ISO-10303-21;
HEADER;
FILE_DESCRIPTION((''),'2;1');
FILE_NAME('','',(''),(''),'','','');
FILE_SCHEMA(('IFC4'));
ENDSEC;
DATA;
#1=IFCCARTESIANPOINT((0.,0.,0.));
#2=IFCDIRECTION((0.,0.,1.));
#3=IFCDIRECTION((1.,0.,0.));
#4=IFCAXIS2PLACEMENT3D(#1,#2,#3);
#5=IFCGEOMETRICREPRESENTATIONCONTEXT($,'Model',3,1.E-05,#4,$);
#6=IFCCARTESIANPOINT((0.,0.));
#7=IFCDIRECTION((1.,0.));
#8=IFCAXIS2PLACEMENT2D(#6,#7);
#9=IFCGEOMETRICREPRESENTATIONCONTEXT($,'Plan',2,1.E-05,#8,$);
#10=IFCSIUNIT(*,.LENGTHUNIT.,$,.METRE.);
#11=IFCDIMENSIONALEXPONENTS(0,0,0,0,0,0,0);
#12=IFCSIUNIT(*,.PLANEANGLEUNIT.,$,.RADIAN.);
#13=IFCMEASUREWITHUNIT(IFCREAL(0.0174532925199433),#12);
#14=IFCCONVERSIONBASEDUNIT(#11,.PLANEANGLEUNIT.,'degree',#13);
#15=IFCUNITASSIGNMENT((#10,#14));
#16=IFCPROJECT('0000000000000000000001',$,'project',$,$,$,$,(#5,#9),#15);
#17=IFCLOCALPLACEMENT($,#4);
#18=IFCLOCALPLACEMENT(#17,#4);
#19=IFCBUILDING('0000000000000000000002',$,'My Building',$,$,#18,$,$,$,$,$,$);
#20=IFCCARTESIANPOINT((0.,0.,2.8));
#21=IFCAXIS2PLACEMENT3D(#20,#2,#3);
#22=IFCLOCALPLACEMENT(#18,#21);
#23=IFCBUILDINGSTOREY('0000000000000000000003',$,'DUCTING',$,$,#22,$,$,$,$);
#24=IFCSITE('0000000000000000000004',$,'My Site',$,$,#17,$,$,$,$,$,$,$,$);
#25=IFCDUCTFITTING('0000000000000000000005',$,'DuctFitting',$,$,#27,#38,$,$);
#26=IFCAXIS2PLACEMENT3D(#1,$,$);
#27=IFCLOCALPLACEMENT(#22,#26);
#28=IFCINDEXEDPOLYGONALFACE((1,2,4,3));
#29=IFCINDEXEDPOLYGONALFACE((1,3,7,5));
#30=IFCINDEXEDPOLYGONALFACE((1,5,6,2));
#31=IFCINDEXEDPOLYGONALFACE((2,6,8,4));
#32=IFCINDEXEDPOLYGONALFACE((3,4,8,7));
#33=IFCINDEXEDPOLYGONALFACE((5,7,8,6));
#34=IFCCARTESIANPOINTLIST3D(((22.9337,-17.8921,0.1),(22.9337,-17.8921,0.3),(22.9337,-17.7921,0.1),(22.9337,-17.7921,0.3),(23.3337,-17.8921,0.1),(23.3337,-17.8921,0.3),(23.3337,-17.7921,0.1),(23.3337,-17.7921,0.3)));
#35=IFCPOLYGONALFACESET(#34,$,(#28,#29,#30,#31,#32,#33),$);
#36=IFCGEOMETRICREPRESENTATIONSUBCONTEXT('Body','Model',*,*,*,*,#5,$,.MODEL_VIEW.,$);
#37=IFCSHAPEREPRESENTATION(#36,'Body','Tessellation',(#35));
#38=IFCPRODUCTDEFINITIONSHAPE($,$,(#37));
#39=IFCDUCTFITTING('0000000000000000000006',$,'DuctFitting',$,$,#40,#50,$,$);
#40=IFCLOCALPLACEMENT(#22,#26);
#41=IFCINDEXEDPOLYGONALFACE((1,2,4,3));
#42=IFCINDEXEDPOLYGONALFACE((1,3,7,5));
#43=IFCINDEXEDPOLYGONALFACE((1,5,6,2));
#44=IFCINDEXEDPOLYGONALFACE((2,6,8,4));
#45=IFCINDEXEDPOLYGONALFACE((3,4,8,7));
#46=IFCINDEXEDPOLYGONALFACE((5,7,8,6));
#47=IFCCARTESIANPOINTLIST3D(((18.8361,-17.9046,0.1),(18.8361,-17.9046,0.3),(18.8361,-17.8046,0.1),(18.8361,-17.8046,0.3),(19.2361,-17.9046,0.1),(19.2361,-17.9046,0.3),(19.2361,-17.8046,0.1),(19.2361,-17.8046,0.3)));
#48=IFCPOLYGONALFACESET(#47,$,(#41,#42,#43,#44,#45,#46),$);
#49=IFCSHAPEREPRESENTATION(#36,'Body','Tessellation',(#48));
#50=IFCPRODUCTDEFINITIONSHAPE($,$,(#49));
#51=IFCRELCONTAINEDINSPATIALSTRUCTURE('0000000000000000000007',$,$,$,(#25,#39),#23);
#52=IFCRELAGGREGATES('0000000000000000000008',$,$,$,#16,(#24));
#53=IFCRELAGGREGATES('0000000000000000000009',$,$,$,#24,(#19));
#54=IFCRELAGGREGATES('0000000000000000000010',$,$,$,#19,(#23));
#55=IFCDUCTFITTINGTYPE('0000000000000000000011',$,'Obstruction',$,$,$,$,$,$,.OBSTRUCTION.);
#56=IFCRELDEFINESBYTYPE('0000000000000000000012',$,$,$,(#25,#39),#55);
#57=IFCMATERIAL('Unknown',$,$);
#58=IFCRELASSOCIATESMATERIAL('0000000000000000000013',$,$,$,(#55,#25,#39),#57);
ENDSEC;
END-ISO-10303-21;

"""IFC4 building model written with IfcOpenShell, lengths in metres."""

from ifc_helpers import new_model, entity, si_unit, converted_unit, frame, origin_with_axes, origin_2d_with_axis, place, context, subcontext, project, spatial, rectangle, extrude, material, material_profile, profile_set, profile_usage, type_object, element, save


model = new_model("IFC4")

# Units and contexts
model_context = context("Model", 3, precision=1e-05, world=origin_with_axes())
plan_context = context("Plan", 2, precision=1e-05, world=origin_2d_with_axis())
body_context = subcontext(model_context, "Body", "Model", "MODEL_VIEW")
ifc_project = project(units=[si_unit("LENGTHUNIT", "METRE"), converted_unit("PLANEANGLEUNIT", "degree", entity("IfcReal", 0.0174532925199433), si_unit("PLANEANGLEUNIT", "RADIAN"), dimensions=[0, 0, 0, 0, 0, 0, 0])], contexts=[model_context, plan_context])

# Site, building, storey
site_placement = place(None, origin_with_axes())
site = spatial("IfcSite", under=ifc_project, at=site_placement, Name="My Site")
building_placement = place(site_placement, origin_with_axes())
building = spatial("IfcBuilding", under=site, at=building_placement, Name="My Building")
storey_placement = place(building_placement, frame((0.0, 0.0, 2.8), z_axis=(0.0, 0.0, 1.0), x_axis=(1.0, 0.0, 0.0)))
storey = spatial("IfcBuildingStorey", under=building, at=storey_placement, Name="DUCTING")

# Shared definitions
ifc_material = material(Name="Unknown")

# Duct fittings
ifc_material_profile_1 = material_profile(ifc_material, rectangle(XDim=0.4, YDim=0.2))
ifc_profile_set_1 = profile_set([ifc_material_profile_1])
duct_fitting_type_1 = type_object("IfcDuctFittingType", Name="Obstruction", PredefinedType="OBSTRUCTION", material=ifc_profile_set_1)
ifc_profile_usage_1 = profile_usage(ifc_profile_set_1, cardinal=5)
duct_fitting_1_placement = place(storey_placement, frame((23.1337, -17.8921, 0.2), z_axis=(0.0, 1.0, 0.0), x_axis=(-1.0, 0.0, 0.0)))
element("IfcDuctFitting", 1, at=duct_fitting_1_placement, inside=storey, type_object=duct_fitting_type_1, material=ifc_profile_usage_1, Name="DuctFitting", context=body_context, shape_type="SweptSolid", body=[
    extrude(rectangle(XDim=0.4, YDim=0.2), origin_with_axes(), (0.0, 0.0, 1.0), 0.1),
])
ifc_profile_usage_2 = profile_usage(ifc_profile_set_1, cardinal=5)
duct_fitting_2_placement = place(storey_placement, frame((19.0361, -17.9046, 0.2), z_axis=(0.0, 1.0, 0.0), x_axis=(-1.0, 0.0, 0.0)))
element("IfcDuctFitting", 2, at=duct_fitting_2_placement, inside=storey, type_object=duct_fitting_type_1, material=ifc_profile_usage_2, Name="DuctFitting", context=body_context, shape_type="SweptSolid", body=[
    extrude(rectangle(XDim=0.4, YDim=0.2), origin_with_axes(), (0.0, 0.0, 1.0), 0.1),
])

save(model, "model.ifc")
